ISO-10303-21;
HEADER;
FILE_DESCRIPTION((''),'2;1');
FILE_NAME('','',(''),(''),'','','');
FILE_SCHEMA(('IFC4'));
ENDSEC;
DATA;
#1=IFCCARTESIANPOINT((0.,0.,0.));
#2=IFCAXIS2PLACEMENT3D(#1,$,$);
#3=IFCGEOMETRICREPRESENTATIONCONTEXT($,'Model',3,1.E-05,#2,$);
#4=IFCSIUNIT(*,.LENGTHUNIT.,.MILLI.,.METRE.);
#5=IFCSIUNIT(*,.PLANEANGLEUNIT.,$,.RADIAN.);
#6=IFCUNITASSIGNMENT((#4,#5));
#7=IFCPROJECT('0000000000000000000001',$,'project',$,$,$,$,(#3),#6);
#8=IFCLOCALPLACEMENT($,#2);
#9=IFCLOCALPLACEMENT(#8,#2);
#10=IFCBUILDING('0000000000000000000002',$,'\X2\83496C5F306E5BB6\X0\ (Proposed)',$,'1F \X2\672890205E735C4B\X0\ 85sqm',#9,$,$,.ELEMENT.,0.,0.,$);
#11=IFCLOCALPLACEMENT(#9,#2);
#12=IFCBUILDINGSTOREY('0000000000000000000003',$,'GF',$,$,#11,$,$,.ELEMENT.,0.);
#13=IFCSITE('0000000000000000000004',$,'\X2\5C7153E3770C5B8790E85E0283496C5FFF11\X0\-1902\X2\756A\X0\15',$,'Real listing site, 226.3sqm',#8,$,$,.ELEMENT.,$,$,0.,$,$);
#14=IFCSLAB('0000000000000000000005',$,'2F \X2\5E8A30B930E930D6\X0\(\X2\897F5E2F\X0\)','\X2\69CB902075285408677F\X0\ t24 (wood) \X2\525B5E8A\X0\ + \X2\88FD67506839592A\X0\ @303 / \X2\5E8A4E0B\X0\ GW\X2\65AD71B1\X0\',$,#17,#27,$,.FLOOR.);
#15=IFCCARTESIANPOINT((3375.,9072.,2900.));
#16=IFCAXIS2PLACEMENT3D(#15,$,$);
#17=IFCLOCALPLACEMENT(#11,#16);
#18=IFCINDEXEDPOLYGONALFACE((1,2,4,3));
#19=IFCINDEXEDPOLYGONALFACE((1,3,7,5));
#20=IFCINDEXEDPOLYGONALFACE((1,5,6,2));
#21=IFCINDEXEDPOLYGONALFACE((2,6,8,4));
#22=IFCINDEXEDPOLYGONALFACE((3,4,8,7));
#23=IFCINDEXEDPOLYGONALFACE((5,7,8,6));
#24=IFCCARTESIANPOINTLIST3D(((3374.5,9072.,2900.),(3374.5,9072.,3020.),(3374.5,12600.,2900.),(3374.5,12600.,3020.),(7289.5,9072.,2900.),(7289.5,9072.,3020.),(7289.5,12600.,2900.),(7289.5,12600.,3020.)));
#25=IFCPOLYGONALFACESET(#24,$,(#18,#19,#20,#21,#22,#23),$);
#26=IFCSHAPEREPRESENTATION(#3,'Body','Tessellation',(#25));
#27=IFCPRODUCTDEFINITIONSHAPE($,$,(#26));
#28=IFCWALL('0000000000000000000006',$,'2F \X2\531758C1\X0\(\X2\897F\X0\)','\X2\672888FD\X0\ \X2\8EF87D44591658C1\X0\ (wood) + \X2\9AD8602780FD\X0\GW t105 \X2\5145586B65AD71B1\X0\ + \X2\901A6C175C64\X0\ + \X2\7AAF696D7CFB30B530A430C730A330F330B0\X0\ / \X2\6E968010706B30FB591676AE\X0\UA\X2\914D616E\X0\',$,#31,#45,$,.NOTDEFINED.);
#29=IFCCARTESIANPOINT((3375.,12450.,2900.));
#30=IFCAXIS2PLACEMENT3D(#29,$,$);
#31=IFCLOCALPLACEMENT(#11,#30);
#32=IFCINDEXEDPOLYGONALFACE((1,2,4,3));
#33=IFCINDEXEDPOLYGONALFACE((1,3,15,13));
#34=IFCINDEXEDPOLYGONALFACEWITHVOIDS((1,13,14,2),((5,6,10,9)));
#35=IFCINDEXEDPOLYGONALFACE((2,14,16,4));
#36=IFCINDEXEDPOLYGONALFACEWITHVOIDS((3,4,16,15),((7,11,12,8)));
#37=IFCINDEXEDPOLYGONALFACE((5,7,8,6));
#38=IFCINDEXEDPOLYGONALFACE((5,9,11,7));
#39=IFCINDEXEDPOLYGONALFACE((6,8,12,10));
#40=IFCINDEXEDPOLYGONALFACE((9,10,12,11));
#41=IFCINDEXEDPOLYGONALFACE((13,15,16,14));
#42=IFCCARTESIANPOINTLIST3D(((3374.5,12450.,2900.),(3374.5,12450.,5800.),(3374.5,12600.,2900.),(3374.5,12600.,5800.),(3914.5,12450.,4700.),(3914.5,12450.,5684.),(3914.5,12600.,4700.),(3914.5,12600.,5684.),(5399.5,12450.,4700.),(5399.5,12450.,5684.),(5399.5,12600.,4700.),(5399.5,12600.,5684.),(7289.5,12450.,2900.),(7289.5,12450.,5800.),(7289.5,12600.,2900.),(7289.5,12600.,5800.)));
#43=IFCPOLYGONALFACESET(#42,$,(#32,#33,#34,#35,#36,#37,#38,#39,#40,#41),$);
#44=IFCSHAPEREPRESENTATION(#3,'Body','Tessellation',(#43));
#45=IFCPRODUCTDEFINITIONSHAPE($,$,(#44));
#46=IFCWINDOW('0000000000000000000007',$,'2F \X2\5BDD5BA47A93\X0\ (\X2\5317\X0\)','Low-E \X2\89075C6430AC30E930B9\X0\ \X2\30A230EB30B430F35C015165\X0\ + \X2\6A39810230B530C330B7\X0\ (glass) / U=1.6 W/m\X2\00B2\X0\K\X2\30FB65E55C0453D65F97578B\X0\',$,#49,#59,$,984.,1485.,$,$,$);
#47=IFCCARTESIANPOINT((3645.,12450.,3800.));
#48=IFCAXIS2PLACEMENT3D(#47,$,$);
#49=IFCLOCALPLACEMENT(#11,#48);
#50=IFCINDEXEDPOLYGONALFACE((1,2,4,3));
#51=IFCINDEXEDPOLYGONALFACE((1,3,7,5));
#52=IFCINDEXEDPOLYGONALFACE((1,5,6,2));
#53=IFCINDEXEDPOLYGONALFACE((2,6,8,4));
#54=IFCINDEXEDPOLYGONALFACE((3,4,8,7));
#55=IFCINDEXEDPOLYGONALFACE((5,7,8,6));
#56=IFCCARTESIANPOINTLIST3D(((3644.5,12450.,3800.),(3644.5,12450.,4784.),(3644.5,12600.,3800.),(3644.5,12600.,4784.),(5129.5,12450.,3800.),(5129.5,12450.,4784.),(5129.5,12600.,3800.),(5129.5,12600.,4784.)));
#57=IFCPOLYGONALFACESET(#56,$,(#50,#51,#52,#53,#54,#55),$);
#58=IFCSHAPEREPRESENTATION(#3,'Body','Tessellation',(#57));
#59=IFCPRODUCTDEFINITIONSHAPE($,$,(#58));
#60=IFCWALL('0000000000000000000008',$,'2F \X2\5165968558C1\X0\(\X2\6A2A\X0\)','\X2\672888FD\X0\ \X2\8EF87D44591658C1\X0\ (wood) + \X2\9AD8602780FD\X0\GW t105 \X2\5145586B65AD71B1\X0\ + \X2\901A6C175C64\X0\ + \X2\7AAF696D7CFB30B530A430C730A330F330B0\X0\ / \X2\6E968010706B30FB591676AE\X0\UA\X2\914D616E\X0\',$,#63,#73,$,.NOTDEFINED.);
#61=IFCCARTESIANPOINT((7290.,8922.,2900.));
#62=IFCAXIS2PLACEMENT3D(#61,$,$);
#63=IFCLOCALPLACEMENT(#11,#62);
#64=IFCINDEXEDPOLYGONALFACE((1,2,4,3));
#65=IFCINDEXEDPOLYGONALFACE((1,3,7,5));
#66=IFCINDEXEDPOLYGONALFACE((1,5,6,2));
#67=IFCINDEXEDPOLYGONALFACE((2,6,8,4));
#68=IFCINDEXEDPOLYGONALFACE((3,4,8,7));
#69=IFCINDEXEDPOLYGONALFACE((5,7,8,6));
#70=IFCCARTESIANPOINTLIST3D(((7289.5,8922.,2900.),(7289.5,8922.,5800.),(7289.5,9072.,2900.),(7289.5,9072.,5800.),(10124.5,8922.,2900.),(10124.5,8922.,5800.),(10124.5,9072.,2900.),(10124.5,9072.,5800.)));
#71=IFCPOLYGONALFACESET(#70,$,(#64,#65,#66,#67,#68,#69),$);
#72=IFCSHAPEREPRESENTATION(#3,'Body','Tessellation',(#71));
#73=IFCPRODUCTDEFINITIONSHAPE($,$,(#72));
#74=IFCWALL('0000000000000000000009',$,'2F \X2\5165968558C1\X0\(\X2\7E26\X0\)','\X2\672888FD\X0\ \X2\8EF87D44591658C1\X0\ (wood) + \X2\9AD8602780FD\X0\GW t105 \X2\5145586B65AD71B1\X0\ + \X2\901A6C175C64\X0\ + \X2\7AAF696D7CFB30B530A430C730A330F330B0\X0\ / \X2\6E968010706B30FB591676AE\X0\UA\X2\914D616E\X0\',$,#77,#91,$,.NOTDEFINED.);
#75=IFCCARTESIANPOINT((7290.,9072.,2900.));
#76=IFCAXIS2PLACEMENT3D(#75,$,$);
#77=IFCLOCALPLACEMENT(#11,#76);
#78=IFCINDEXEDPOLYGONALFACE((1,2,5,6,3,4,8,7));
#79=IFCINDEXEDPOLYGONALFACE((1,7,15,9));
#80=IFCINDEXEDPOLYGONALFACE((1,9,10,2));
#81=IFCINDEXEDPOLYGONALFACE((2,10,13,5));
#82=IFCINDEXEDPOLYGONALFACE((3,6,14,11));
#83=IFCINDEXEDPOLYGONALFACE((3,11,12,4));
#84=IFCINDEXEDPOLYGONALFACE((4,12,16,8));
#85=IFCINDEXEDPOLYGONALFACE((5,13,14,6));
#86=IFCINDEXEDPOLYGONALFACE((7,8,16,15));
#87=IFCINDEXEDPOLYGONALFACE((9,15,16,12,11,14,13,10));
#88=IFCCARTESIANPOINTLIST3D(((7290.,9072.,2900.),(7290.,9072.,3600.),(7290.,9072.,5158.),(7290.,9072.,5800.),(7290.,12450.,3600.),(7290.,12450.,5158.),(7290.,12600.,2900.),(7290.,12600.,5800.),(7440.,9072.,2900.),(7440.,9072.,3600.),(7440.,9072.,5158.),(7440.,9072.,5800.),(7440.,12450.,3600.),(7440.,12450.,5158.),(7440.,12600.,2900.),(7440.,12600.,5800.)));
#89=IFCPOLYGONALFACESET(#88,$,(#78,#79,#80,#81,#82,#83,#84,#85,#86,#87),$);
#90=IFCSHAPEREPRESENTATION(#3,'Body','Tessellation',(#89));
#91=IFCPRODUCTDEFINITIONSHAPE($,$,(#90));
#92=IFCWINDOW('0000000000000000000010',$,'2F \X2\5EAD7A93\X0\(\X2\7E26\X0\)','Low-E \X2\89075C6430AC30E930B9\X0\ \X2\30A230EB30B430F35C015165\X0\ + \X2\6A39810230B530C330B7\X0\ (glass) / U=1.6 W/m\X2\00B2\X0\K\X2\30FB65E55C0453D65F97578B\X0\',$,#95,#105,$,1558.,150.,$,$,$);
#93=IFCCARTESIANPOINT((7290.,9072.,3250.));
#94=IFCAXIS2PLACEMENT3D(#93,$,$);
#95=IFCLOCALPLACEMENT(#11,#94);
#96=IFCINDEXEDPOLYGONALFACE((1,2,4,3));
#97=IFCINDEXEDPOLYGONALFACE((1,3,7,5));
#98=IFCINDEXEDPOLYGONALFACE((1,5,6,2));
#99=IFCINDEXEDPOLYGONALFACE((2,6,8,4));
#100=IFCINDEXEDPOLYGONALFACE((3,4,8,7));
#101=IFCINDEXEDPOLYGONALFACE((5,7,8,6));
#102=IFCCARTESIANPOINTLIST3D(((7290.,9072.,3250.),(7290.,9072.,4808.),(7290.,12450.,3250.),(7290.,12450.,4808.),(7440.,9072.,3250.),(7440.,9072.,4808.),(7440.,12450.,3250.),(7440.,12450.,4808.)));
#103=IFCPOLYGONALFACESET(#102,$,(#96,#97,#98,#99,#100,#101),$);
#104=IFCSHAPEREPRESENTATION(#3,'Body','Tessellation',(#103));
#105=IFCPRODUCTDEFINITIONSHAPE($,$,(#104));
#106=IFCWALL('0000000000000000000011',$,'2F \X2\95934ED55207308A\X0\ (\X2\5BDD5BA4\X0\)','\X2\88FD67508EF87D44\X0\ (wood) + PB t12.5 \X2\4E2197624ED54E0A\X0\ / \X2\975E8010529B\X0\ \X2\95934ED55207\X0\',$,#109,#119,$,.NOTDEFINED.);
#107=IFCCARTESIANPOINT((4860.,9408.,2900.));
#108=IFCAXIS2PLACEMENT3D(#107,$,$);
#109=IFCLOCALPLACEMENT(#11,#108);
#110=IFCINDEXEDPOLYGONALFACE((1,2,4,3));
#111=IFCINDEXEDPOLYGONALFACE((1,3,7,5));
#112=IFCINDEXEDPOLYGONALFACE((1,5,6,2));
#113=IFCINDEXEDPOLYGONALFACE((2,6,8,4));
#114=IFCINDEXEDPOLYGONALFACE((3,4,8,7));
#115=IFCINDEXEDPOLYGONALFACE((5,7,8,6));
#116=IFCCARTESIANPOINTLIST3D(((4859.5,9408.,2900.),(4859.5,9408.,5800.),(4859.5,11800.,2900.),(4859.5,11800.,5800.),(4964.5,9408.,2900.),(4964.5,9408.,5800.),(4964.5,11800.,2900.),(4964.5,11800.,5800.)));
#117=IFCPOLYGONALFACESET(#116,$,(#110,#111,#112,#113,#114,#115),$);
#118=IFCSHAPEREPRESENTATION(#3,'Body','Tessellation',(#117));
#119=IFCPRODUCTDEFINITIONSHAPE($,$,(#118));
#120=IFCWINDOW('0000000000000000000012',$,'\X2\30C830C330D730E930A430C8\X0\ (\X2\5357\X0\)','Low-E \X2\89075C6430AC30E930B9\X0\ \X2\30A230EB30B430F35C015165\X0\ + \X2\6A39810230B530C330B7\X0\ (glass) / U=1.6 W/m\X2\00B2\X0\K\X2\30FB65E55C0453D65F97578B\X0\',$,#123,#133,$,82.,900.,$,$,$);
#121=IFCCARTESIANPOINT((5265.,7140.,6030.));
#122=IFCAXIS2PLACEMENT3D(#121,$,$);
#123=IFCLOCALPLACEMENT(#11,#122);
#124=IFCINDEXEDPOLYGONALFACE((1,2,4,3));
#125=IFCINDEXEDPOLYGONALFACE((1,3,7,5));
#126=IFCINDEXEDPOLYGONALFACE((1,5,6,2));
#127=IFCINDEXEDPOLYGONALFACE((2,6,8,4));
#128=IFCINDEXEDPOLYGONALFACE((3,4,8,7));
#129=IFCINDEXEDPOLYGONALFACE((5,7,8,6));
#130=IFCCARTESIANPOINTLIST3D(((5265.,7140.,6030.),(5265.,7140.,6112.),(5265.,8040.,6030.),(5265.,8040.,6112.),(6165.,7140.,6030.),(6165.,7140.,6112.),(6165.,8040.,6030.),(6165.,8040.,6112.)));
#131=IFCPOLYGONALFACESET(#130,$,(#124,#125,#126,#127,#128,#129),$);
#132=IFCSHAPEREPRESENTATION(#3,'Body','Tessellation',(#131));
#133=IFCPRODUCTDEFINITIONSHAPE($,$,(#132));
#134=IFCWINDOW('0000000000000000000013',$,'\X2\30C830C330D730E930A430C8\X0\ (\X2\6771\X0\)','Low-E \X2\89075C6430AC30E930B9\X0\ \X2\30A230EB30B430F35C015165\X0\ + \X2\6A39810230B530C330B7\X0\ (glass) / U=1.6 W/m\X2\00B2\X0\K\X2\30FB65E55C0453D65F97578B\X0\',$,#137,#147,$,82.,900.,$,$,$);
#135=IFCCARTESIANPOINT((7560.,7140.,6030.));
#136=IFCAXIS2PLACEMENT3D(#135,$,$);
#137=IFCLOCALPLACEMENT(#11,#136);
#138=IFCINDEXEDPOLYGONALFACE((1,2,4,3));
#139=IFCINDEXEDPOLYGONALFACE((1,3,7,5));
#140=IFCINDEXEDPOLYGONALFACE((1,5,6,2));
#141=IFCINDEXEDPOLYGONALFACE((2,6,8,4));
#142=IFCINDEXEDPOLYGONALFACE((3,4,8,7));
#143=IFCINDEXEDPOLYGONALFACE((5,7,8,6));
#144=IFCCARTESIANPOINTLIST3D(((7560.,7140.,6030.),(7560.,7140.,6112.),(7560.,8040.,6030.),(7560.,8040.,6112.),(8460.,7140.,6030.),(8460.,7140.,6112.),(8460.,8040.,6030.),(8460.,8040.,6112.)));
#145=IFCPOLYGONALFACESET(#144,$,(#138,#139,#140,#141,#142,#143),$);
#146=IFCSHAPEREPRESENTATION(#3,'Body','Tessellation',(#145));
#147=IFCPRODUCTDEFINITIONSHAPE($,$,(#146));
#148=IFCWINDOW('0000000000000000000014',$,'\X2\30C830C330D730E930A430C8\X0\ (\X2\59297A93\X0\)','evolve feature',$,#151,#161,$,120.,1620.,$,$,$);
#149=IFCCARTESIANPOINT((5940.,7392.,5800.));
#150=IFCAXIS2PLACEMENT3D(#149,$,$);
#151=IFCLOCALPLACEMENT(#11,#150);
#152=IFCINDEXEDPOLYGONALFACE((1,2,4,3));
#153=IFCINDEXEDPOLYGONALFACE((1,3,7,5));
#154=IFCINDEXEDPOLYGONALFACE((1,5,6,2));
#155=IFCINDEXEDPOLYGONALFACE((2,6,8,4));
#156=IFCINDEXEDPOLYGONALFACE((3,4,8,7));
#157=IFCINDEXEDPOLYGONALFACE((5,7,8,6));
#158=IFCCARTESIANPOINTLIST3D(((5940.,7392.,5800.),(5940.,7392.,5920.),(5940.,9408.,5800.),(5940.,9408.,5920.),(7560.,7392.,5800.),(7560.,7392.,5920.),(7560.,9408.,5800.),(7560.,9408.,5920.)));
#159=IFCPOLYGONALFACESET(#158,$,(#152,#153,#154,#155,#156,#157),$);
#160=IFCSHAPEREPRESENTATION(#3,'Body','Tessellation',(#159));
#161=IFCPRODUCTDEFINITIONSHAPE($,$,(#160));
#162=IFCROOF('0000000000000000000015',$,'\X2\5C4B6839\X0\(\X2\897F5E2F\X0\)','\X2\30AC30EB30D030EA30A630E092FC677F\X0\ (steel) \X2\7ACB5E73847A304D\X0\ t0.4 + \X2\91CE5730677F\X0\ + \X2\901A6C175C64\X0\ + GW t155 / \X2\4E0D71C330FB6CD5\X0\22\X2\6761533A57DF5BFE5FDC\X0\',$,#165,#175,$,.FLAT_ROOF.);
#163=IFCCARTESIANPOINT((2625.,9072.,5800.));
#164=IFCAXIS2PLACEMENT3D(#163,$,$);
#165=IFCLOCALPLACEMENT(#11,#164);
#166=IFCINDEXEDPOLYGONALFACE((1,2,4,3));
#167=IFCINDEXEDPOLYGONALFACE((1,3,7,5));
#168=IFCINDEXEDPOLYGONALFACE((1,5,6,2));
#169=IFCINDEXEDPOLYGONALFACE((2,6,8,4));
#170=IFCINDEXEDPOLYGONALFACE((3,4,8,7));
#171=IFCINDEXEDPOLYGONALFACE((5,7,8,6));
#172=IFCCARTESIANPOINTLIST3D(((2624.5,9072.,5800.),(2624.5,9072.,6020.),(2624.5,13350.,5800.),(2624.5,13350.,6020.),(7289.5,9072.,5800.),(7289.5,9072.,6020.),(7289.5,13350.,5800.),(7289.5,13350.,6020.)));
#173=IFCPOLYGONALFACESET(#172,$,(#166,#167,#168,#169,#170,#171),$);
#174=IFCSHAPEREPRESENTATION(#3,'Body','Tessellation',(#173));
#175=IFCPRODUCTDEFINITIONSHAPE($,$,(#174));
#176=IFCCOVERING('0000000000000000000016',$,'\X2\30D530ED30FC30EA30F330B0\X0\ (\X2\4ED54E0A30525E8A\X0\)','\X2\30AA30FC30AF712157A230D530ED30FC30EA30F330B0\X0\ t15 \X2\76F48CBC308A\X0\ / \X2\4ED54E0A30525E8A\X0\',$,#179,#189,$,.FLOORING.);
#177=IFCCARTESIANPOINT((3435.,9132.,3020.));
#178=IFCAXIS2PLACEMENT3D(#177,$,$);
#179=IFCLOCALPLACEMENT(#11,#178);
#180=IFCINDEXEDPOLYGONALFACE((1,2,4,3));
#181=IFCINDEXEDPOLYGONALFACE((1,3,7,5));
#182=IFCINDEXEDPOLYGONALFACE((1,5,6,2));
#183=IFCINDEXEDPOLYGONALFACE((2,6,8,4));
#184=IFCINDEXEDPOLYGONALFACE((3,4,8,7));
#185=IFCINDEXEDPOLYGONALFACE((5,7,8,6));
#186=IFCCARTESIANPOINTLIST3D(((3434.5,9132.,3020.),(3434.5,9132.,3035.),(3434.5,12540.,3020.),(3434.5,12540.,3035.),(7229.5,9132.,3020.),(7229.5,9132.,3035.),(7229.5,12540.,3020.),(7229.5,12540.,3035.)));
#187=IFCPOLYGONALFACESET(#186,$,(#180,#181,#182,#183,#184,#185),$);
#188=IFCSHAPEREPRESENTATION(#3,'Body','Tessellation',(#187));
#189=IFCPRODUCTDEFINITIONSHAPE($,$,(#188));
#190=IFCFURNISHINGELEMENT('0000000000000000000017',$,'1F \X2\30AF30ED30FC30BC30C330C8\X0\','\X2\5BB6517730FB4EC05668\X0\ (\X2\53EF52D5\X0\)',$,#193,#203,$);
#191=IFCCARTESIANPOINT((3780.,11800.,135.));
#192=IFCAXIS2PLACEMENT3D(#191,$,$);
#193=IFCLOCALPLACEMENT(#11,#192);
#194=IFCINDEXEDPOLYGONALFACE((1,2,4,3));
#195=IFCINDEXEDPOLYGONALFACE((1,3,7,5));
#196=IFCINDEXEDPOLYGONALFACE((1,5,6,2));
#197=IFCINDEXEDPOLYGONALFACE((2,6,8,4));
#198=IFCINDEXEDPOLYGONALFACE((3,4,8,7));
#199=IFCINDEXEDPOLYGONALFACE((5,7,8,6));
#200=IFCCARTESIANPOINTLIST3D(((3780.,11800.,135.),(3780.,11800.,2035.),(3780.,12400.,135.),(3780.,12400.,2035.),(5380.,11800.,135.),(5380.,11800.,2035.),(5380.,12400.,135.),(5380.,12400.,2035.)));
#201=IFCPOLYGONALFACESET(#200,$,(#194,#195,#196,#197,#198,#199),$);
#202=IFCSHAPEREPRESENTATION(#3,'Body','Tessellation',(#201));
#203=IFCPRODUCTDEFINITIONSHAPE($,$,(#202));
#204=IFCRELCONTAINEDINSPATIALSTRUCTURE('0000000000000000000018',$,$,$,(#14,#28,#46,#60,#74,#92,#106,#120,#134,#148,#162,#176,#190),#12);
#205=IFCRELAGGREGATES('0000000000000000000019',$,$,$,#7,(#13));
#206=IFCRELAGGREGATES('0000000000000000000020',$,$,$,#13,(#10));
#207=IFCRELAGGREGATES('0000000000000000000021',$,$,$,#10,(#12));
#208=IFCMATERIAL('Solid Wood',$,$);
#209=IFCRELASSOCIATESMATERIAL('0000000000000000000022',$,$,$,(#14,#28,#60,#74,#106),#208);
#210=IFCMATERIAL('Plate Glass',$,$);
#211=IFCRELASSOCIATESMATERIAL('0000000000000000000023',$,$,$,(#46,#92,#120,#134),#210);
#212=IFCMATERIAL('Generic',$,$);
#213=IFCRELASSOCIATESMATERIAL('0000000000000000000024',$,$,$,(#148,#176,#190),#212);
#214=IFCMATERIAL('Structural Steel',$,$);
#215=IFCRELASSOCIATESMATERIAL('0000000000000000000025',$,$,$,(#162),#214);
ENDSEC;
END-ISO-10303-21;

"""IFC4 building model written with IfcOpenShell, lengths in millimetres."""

from ifc_helpers import new_model, si_unit, frame, frame_2d, origin, place, context, project, spatial, rectangle, extrude, material, element, fill, save


model = new_model("IFC4")

# Units and contexts
model_context = context("Model", 3, precision=1e-05, world=origin())
ifc_project = project(units=[si_unit("LENGTHUNIT", "METRE", prefix="MILLI"), si_unit("PLANEANGLEUNIT", "RADIAN")], contexts=[model_context])

# Site, building, storey
site_placement = place(None, origin())
site = spatial("IfcSite", under=ifc_project, at=site_placement, Name="山口県宇部市草江１-1902番15", ObjectType="Real listing site, 226.3sqm", CompositionType="ELEMENT", RefElevation=0.0)
building_placement = place(site_placement, origin())
building = spatial("IfcBuilding", under=site, at=building_placement, Name="草江の家 (Proposed)", ObjectType="1F 木造平屋 85sqm", CompositionType="ELEMENT", ElevationOfRefHeight=0.0, ElevationOfTerrain=0.0)
storey_placement = place(building_placement, origin())
storey = spatial("IfcBuildingStorey", under=building, at=storey_placement, Name="GF", CompositionType="ELEMENT", Elevation=0.0)

# Slab
ifc_material_1 = material(Name="Solid Wood")
slab_placement = place(storey_placement, frame((3375.0, 9072.0, 2900.0)))
element("IfcSlab", 1, at=slab_placement, inside=storey, material=ifc_material_1, Name="2F 床スラブ(西帯)", Description="構造用合板 t24 (wood) 剛床 + 製材根太 @303 / 床下 GW断熱", PredefinedType="FLOOR", context=model_context, shape_type="SweptSolid", body=[
    extrude(rectangle(XDim=3915.0, YDim=3528.0, at=frame_2d((1957.0, 1764.0))), frame((3375.0, 9072.0, 2900.0)), (0.0, 0.0, 1.0), 120.0),
])

# Wall, opening, window
wall_1_placement = place(storey_placement, frame((3375.0, 12450.0, 2900.0)))
wall_1 = element("IfcWall", 2, at=wall_1_placement, inside=storey, material=ifc_material_1, Name="2F 北壁(西)", Description="木製 軸組外壁 (wood) + 高性能GW t105 充填断熱 + 通気層 + 窯業系サイディング / 準耐火・外皮UA配慮", PredefinedType="NOTDEFINED", context=model_context, shape_type="SweptSolid", body=[
    extrude(rectangle(XDim=3915.0, YDim=150.0, at=frame_2d((1957.0, 75.0))), frame((3375.0, 12450.0, 2900.0)), (0.0, 0.0, 1.0), 2900.0),
])
opening_1_placement = place(storey_placement, frame((3645.0, 12450.0, 3800.0)))
opening_1 = element("IfcOpeningElement", 3, at=opening_1_placement, cuts=wall_1, PredefinedType="NOTDEFINED", context=model_context, shape_type="SweptSolid", body=[
    extrude(rectangle(XDim=1485.0, YDim=150.0, at=frame_2d((742.0, 75.0))), frame((3645.0, 12450.0, 3800.0)), (0.0, 0.0, 1.0), 984.0),
])
ifc_material_2 = material(Name="Plate Glass")
window_1_placement = place(storey_placement, frame((3645.0, 12450.0, 3800.0)))
window_1 = element("IfcWindow", 4, at=window_1_placement, inside=storey, material=ifc_material_2, Name="2F 寝室窓 (北)", Description="Low-E 複層ガラス アルゴン封入 + 樹脂サッシ (glass) / U=1.6 W/m²K・日射取得型", OverallHeight=984.0, OverallWidth=1485.0, context=model_context, shape_type="SweptSolid", body=[
    extrude(rectangle(XDim=1485.0, YDim=150.0, at=frame_2d((742.0, 75.0))), frame((3645.0, 12450.0, 3800.0)), (0.0, 0.0, 1.0), 984.0),
])
fill(opening_1, window_1)

# Wall
wall_2_placement = place(storey_placement, frame((7290.0, 8922.0, 2900.0)))
element("IfcWall", 5, at=wall_2_placement, inside=storey, material=ifc_material_1, Name="2F 入隅壁(横)", Description="木製 軸組外壁 (wood) + 高性能GW t105 充填断熱 + 通気層 + 窯業系サイディング / 準耐火・外皮UA配慮", PredefinedType="NOTDEFINED", context=model_context, shape_type="SweptSolid", body=[
    extrude(rectangle(XDim=2835.0, YDim=150.0, at=frame_2d((1417.0, 75.0))), frame((7290.0, 8922.0, 2900.0)), (0.0, 0.0, 1.0), 2900.0),
])

# Wall, opening, window
wall_3_placement = place(storey_placement, frame((7290.0, 9072.0, 2900.0)))
wall_3 = element("IfcWall", 6, at=wall_3_placement, inside=storey, material=ifc_material_1, Name="2F 入隅壁(縦)", Description="木製 軸組外壁 (wood) + 高性能GW t105 充填断熱 + 通気層 + 窯業系サイディング / 準耐火・外皮UA配慮", PredefinedType="NOTDEFINED", context=model_context, shape_type="SweptSolid", body=[
    extrude(rectangle(XDim=150.0, YDim=3528.0, at=frame_2d((75.0, 1764.0))), frame((7290.0, 9072.0, 2900.0)), (0.0, 0.0, 1.0), 2900.0),
])
opening_2_placement = place(storey_placement, frame((7290.0, 9072.0, 3250.0)))
opening_2 = element("IfcOpeningElement", 7, at=opening_2_placement, cuts=wall_3, PredefinedType="NOTDEFINED", context=model_context, shape_type="SweptSolid", body=[
    extrude(rectangle(XDim=150.0, YDim=3378.0, at=frame_2d((75.0, 1689.0))), frame((7290.0, 9072.0, 3250.0)), (0.0, 0.0, 1.0), 1558.0),
])
window_2_placement = place(storey_placement, frame((7290.0, 9072.0, 3250.0)))
window_2 = element("IfcWindow", 8, at=window_2_placement, inside=storey, material=ifc_material_2, Name="2F 庭窓(縦)", Description="Low-E 複層ガラス アルゴン封入 + 樹脂サッシ (glass) / U=1.6 W/m²K・日射取得型", OverallHeight=1558.0, OverallWidth=150.0, context=model_context, shape_type="SweptSolid", body=[
    extrude(rectangle(XDim=150.0, YDim=3378.0, at=frame_2d((75.0, 1689.0))), frame((7290.0, 9072.0, 3250.0)), (0.0, 0.0, 1.0), 1558.0),
])
fill(opening_2, window_2)

# Wall
wall_4_placement = place(storey_placement, frame((4860.0, 9408.0, 2900.0)))
element("IfcWall", 9, at=wall_4_placement, inside=storey, material=ifc_material_1, Name="2F 間仕切り (寝室)", Description="製材軸組 (wood) + PB t12.5 両面仕上 / 非耐力 間仕切", PredefinedType="NOTDEFINED", context=model_context, shape_type="SweptSolid", body=[
    extrude(rectangle(XDim=105.0, YDim=2392.0, at=frame_2d((52.0, 1196.0))), frame((4860.0, 9408.0, 2900.0)), (0.0, 0.0, 1.0), 2900.0),
])

# Windows
window_3_placement = place(storey_placement, frame((5265.0, 7140.0, 6030.0)))
element("IfcWindow", 10, at=window_3_placement, inside=storey, material=ifc_material_2, Name="トップライト (南)", Description="Low-E 複層ガラス アルゴン封入 + 樹脂サッシ (glass) / U=1.6 W/m²K・日射取得型", OverallHeight=82.0, OverallWidth=900.0, context=model_context, shape_type="SweptSolid", body=[
    extrude(rectangle(XDim=900.0, YDim=900.0, at=frame_2d((450.0, 450.0))), frame((5265.0, 7140.0, 6030.0)), (0.0, 0.0, 1.0), 82.0),
])
window_4_placement = place(storey_placement, frame((7560.0, 7140.0, 6030.0)))
element("IfcWindow", 11, at=window_4_placement, inside=storey, material=ifc_material_2, Name="トップライト (東)", Description="Low-E 複層ガラス アルゴン封入 + 樹脂サッシ (glass) / U=1.6 W/m²K・日射取得型", OverallHeight=82.0, OverallWidth=900.0, context=model_context, shape_type="SweptSolid", body=[
    extrude(rectangle(XDim=900.0, YDim=900.0, at=frame_2d((450.0, 450.0))), frame((7560.0, 7140.0, 6030.0)), (0.0, 0.0, 1.0), 82.0),
])
ifc_material_3 = material(Name="Generic")
window_5_placement = place(storey_placement, frame((5940.0, 7392.0, 5800.0)))
element("IfcWindow", 12, at=window_5_placement, inside=storey, material=ifc_material_3, Name="トップライト (天窓)", Description="evolve feature", OverallHeight=120.0, OverallWidth=1620.0, context=model_context, shape_type="SweptSolid", body=[
    extrude(rectangle(XDim=1620.0, YDim=2016.0, at=frame_2d((810.0, 1008.0))), frame((5940.0, 7392.0, 5800.0)), (0.0, 0.0, 1.0), 120.0),
])

# Roof
ifc_material_4 = material(Name="Structural Steel")
for number, where, name in (
    (13, (2625.0, 9072.0, 5800.0), "屋根(西帯)"),
):
    element("IfcRoof", number, at=place(storey_placement, frame(where)), inside=storey, material=ifc_material_4, Name=name, Description="ガルバリウム鋼板 (steel) 立平葺き t0.4 + 野地板 + 通気層 + GW t155 / 不燃・法22条区域対応", PredefinedType="FLAT_ROOF", context=model_context, shape_type="SweptSolid", body=[
        extrude(rectangle(XDim=4665.0, YDim=4278.0, at=frame_2d((2332.0, 2139.0))), frame((2625.0, 9072.0, 5800.0)), (0.0, 0.0, 1.0), 220.0),
    ])

# Covering
covering_placement = place(storey_placement, frame((3435.0, 9132.0, 3020.0)))
element("IfcCovering", 14, at=covering_placement, inside=storey, material=ifc_material_3, Name="フローリング (仕上げ床)", Description="オーク無垢フローリング t15 直貼り / 仕上げ床", PredefinedType="FLOORING", context=model_context, shape_type="SweptSolid", body=[
    extrude(rectangle(XDim=3795.0, YDim=3408.0, at=frame_2d((1897.0, 1704.0))), frame((3435.0, 9132.0, 3020.0)), (0.0, 0.0, 1.0), 15.0),
])

# Furnishing element
furnishing_1_placement = place(storey_placement, frame((3780.0, 11800.0, 135.0)))
element("IfcFurnishingElement", 15, at=furnishing_1_placement, inside=storey, material=ifc_material_3, Name="1F クローゼット", Description="家具・什器 (可動)", context=model_context, shape_type="SweptSolid", body=[
    extrude(rectangle(XDim=1600.0, YDim=600.0, at=frame_2d((800.0, 300.0))), frame((3780.0, 11800.0, 135.0)), (0.0, 0.0, 1.0), 1900.0),
])

save(model, "model.ifc")
